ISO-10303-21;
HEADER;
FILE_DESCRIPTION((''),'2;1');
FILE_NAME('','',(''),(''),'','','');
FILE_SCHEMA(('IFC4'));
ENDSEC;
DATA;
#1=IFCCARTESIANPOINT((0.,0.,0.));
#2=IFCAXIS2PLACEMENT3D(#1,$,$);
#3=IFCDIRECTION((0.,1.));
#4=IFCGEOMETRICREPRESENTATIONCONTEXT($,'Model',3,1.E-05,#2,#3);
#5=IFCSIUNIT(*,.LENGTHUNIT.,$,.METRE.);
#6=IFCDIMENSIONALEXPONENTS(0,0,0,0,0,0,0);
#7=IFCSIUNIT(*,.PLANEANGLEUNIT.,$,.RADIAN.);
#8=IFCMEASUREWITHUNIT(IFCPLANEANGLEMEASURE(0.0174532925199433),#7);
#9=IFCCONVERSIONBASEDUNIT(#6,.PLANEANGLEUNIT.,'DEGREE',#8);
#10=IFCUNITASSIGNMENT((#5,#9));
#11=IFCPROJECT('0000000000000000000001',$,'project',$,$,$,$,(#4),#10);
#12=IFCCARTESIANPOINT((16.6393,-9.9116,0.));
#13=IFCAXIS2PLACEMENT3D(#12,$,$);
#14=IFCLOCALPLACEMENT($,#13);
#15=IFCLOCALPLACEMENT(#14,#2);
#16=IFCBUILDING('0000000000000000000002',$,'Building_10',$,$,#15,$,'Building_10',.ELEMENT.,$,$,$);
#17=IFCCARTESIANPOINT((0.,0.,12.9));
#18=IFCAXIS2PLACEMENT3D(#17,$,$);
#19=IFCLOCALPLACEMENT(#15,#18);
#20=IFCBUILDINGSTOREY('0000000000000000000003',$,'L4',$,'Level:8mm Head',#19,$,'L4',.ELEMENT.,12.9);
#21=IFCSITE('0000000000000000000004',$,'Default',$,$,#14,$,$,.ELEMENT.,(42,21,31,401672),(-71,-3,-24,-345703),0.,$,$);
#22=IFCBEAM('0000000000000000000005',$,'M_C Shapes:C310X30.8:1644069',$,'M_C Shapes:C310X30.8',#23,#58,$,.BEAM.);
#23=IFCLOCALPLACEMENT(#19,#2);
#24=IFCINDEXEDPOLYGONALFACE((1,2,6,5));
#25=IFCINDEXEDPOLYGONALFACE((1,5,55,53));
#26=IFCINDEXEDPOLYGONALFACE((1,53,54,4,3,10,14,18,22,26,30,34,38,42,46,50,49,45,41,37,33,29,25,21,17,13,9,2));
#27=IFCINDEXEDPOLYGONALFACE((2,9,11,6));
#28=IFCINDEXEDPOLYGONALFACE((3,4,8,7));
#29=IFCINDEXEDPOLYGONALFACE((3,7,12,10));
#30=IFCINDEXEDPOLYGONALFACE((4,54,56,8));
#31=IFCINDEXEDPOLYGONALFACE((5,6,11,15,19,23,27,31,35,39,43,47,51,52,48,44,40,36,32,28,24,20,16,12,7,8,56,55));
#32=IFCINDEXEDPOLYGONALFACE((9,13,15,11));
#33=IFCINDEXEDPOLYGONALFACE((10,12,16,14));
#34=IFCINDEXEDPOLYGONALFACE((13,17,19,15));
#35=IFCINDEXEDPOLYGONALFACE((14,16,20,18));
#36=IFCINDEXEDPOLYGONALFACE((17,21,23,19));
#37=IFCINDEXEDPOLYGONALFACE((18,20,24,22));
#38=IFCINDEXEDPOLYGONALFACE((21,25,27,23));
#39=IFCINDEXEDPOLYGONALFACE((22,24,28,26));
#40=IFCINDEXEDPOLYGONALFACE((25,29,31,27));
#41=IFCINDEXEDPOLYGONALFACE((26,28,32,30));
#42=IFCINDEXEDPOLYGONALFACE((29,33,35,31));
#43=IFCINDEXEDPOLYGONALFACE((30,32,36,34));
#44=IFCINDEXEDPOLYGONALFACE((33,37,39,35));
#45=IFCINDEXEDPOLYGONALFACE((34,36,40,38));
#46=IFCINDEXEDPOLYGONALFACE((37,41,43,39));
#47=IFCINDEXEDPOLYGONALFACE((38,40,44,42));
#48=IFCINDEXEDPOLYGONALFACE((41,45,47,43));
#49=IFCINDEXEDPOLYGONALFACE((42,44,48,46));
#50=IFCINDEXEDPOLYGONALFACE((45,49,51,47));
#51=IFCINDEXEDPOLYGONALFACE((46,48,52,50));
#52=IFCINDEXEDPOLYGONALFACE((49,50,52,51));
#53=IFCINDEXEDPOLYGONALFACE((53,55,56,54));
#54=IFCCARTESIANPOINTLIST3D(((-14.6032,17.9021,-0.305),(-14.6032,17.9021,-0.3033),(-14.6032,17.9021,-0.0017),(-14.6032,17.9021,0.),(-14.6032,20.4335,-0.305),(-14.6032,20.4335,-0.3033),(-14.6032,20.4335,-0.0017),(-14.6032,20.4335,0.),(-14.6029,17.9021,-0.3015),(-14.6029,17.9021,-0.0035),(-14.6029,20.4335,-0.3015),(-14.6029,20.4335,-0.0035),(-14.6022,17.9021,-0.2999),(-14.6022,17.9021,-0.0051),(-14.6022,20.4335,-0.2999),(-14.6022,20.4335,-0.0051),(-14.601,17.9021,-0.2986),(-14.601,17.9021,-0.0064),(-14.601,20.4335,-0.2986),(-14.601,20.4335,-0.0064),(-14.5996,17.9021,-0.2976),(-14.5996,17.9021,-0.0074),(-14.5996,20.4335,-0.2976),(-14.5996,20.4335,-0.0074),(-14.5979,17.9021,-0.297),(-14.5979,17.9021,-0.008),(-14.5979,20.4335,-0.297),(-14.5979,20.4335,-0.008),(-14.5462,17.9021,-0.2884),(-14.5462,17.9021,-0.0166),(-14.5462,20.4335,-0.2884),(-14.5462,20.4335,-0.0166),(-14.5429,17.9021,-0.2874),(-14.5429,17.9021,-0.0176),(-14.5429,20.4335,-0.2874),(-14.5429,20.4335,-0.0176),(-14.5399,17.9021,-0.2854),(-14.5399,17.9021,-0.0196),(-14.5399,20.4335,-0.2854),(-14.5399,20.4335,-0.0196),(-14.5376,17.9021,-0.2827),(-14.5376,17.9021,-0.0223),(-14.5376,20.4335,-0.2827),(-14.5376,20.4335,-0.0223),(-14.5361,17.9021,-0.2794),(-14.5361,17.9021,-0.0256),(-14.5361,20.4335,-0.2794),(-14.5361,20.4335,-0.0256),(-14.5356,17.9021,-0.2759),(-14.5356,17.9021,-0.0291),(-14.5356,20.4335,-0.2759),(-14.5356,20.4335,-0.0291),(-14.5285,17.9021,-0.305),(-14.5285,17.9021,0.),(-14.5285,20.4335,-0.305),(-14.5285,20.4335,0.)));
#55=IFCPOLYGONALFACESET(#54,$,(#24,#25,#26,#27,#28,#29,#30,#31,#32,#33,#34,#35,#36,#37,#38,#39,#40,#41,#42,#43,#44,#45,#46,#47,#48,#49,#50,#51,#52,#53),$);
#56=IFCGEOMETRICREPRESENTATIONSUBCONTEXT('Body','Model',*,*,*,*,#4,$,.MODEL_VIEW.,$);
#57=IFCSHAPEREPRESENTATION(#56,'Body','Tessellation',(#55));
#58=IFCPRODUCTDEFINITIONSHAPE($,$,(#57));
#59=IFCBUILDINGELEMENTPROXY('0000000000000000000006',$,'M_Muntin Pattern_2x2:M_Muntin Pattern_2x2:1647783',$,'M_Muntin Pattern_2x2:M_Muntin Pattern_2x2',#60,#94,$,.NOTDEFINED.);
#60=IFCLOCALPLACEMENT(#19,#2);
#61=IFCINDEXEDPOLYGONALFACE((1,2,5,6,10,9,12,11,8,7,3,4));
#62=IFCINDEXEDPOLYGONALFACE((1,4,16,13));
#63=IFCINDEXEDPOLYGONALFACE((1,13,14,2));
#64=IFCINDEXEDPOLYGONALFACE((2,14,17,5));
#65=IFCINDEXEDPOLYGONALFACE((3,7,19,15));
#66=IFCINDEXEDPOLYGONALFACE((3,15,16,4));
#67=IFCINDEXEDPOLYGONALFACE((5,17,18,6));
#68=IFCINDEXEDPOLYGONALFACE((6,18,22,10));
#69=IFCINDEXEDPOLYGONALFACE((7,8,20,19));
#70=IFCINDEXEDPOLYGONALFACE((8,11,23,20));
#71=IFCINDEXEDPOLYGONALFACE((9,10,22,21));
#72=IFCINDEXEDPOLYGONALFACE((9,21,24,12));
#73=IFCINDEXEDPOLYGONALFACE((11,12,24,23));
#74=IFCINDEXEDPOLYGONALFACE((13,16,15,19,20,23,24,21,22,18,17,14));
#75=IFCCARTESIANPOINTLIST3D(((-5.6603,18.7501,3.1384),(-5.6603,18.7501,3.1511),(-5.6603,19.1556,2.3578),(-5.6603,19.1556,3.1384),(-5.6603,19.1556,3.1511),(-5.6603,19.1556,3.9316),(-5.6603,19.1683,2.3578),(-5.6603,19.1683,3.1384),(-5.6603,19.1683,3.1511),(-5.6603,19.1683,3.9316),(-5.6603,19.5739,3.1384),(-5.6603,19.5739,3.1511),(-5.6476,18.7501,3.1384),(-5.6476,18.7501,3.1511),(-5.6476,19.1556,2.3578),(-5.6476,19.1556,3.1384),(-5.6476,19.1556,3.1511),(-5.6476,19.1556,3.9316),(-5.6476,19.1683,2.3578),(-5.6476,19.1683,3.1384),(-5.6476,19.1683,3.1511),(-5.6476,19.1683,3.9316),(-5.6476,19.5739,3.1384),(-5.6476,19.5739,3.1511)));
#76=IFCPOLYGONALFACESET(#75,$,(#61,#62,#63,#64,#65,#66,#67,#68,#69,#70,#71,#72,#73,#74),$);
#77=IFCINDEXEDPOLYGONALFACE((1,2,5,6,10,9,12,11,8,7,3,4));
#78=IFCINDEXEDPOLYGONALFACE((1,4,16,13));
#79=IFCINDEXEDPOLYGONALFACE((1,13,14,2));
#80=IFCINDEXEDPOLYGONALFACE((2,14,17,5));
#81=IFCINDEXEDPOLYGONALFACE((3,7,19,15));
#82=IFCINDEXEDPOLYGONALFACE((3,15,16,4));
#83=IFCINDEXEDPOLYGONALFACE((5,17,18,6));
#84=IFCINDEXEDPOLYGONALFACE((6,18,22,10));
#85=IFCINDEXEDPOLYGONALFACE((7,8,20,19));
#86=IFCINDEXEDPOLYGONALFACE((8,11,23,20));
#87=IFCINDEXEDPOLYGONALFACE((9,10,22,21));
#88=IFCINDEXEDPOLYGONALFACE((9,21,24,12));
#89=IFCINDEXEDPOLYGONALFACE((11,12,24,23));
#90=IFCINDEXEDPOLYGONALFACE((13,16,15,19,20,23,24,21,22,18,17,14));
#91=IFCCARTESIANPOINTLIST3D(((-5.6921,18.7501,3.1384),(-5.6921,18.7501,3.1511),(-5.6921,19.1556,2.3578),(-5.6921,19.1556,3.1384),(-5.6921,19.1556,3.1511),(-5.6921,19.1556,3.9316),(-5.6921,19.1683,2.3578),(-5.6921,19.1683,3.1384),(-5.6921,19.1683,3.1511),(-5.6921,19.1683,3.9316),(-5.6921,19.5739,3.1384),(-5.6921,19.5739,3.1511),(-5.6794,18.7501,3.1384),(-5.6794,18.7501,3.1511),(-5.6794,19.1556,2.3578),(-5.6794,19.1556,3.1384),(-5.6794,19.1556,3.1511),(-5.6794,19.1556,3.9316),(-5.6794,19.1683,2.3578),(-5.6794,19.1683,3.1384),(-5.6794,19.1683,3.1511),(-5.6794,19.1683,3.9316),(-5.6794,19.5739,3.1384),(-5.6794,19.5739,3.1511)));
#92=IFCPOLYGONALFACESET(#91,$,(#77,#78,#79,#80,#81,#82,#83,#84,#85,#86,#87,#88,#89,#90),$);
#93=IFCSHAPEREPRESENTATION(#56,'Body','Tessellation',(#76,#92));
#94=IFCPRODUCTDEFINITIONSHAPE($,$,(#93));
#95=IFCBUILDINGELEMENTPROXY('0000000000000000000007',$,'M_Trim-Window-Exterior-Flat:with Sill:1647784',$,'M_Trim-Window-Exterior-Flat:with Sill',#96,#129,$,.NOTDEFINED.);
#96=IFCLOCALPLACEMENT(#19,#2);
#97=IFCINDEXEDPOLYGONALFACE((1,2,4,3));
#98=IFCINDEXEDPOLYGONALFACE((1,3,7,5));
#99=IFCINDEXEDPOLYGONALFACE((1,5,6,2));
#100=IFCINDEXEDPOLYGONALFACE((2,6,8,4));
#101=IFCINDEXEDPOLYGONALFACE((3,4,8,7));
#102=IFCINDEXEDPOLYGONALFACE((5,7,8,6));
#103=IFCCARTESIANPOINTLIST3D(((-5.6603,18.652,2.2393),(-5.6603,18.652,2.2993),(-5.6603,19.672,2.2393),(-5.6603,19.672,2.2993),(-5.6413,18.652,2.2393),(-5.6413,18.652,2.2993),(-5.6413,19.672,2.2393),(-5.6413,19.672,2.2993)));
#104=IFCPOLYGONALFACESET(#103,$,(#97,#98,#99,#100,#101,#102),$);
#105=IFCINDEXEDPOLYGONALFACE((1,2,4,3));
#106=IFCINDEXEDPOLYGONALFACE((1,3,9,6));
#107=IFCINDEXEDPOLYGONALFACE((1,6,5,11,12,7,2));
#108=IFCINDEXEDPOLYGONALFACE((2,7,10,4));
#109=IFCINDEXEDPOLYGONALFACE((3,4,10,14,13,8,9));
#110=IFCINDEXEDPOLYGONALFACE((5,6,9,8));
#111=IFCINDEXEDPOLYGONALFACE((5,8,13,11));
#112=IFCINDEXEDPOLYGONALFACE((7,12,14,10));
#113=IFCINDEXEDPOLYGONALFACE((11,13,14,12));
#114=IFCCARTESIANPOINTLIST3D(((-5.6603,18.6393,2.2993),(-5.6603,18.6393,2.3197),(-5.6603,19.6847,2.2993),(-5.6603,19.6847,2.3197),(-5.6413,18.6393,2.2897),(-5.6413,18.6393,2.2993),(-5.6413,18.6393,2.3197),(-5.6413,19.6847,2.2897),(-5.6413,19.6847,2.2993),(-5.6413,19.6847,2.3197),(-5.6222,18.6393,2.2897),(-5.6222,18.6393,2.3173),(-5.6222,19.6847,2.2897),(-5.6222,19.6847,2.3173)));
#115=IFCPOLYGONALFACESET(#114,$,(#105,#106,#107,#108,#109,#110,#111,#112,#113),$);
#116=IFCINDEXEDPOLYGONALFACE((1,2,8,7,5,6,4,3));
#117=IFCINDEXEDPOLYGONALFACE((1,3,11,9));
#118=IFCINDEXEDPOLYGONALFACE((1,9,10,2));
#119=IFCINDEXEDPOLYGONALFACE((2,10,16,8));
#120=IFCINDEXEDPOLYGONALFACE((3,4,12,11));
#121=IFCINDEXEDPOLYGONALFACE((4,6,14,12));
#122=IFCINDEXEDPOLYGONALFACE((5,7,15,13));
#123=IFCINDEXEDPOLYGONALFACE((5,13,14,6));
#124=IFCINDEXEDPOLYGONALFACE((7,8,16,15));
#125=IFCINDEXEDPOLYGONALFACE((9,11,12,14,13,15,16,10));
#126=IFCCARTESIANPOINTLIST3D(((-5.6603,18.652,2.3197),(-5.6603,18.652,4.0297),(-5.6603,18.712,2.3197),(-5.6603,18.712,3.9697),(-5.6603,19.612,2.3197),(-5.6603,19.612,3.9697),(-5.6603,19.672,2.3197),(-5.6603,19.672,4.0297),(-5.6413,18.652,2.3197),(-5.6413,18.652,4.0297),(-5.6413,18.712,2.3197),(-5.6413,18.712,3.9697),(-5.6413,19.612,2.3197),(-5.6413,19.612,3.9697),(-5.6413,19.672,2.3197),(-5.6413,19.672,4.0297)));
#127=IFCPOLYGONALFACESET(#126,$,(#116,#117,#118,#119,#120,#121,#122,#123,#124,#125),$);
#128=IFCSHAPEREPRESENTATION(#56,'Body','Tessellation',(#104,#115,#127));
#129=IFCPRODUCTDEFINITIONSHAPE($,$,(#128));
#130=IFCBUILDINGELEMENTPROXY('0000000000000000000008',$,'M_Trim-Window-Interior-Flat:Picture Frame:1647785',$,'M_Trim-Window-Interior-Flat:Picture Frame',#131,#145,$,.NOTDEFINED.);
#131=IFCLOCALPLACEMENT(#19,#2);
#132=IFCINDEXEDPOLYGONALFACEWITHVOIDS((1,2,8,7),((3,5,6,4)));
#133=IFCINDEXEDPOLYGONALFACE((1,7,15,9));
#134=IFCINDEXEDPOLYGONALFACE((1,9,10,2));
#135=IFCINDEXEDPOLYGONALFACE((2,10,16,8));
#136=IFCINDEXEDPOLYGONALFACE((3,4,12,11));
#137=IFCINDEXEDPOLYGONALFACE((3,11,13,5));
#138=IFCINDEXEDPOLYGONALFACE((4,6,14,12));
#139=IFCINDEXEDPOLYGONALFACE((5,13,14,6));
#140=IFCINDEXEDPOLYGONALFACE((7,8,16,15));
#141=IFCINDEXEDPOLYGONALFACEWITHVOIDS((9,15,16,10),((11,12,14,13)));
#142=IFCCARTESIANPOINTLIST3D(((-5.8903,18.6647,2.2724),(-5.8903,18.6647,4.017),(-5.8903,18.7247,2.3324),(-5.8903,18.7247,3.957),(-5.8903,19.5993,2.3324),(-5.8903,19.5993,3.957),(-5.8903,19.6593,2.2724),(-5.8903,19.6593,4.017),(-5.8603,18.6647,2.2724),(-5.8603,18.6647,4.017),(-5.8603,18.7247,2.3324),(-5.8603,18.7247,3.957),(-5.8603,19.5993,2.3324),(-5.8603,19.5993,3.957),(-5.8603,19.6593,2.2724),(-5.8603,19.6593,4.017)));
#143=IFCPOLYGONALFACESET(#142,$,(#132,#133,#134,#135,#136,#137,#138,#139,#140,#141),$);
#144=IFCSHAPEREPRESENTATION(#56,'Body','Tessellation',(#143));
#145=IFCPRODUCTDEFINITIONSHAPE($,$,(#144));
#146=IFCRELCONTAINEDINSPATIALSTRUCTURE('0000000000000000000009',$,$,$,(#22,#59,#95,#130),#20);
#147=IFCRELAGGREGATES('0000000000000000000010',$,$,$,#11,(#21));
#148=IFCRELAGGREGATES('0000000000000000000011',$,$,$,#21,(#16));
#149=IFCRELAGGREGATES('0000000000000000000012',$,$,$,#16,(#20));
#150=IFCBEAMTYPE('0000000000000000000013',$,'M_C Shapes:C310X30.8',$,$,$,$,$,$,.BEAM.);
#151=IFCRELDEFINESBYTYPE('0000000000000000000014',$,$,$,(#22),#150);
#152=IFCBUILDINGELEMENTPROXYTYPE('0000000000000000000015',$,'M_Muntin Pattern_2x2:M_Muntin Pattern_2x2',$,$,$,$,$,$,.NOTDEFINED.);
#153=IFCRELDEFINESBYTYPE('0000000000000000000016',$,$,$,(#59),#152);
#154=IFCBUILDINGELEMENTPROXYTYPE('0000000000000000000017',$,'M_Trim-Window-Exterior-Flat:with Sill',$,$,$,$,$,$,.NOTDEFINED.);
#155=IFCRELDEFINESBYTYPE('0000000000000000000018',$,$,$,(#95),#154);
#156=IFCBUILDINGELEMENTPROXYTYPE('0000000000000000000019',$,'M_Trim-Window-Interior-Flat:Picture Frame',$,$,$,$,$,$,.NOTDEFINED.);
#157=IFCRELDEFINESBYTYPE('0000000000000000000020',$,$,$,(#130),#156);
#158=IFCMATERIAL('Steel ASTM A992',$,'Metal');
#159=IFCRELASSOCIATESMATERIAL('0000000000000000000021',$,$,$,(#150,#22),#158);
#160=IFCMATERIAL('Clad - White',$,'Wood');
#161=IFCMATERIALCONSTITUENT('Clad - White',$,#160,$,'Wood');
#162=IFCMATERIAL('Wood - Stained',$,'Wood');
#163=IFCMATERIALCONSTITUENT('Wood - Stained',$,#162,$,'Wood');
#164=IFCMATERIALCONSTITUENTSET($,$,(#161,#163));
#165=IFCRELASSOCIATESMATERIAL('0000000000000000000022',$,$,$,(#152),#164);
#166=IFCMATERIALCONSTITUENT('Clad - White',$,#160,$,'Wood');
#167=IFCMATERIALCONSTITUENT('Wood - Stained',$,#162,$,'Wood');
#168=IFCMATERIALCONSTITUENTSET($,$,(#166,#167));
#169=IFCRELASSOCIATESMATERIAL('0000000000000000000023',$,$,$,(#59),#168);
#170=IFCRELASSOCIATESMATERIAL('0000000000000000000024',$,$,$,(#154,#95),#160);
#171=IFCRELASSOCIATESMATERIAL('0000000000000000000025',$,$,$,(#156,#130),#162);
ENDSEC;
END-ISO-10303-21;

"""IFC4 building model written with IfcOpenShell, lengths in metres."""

from ifc_helpers import new_model, entity, si_unit, converted_unit, direction, frame, origin, place, context, subcontext, project, spatial, line, arc, indexed_curve, outline, extrude, source, transform, mapped, material, constituent, constituent_set, type_object, type_shapes, element, save


model = new_model("IFC4")

# Units and contexts
model_context = context("Model", 3, precision=1e-05, world=origin(), true_north=direction((0.0, 1.0)))
body_context = subcontext(model_context, "Body", "Model", "MODEL_VIEW")
ifc_project = project(units=[si_unit("LENGTHUNIT", "METRE"), converted_unit("PLANEANGLEUNIT", "DEGREE", entity("IfcPlaneAngleMeasure", 0.0174532925199433), si_unit("PLANEANGLEUNIT", "RADIAN"), dimensions=[0, 0, 0, 0, 0, 0, 0])], contexts=[model_context])

# Site, building, storey
site_placement = place(None, frame((16.6393, -9.9116, 0.0)))
site = spatial("IfcSite", under=ifc_project, at=site_placement, Name="Default", CompositionType="ELEMENT", RefLatitude=(42, 21, 31, 401672), RefLongitude=(-71, -3, -24, -345703), RefElevation=0.0)
building_placement = place(site_placement, origin())
building = spatial("IfcBuilding", under=site, at=building_placement, Name="Building_10", LongName="Building_10", CompositionType="ELEMENT")
storey_placement = place(building_placement, frame((0.0, 0.0, 12.9)))
storey = spatial("IfcBuildingStorey", under=building, at=storey_placement, Name="L4", ObjectType="Level:8mm Head", LongName="L4", CompositionType="ELEMENT", Elevation=12.9)

# Shared definitions
ifc_material_1 = material(Name="Steel ASTM A992", Category="Metal")

# Beam
beam_type_1 = type_object("IfcBeamType", Name="M_C Shapes:C310X30.8", PredefinedType="BEAM", material=ifc_material_1)
shared_shape_1 = source(origin(), body_context, "Body", "SweptSolid", [
    extrude(outline(indexed_curve([(-0.0406, -0.1525), (0.0341, -0.1525), (0.0341, -0.1508), (0.0326, -0.1467), (0.0288, -0.1445), (-0.0228, -0.1359), (-0.0305, -0.1316), (-0.0335, -0.1234), (-0.0335, 0.1234), (-0.0305, 0.1316), (-0.0228, 0.1359), (0.0288, 0.1445), (0.0326, 0.1467), (0.0341, 0.1508), (0.0341, 0.1525), (-0.0406, 0.1525)], segments=[line(1, 2, 3), arc(3, 4, 5), line(5, 6), arc(6, 7, 8), line(8, 9), arc(9, 10, 11), line(11, 12), arc(12, 13, 14), line(14, 15, 16, 1)], self_intersect=False)), frame((-1.2657, -0.0229, 0.0), z_axis=(1.0, 0.0, 0.0), x_axis=(0.0, -1.0, 0.0)), (0.0, 0.0, 1.0), 2.5314),
])
type_shapes(beam_type_1, [shared_shape_1])
for number, where, z_axis, x_axis, name in (
    (1, (-14.5462, 19.1678, -0.1525), (0.0, 0.0, 1.0), (0.0, -1.0, 0.0), "M_C Shapes:C310X30.8:1644069"),
):
    element("IfcBeam", number, at=place(storey_placement, frame(where, z_axis=z_axis, x_axis=x_axis)), inside=storey, type_object=beam_type_1, material=ifc_material_1, Name=name, ObjectType="M_C Shapes:C310X30.8", PredefinedType="BEAM", context=body_context, shape_type="MappedRepresentation", body=[
        mapped(shared_shape_1, transform((0.0, 0.0, 0.0), scale=1.0)),
    ])

# Building element proxies
ifc_material_2 = material(Name="Clad - White", Category="Wood")
ifc_constituent_1 = constituent(ifc_material_2, Name="Clad - White", Category="Wood")
ifc_material_3 = material(Name="Wood - Stained", Category="Wood")
ifc_constituent_2 = constituent(ifc_material_3, Name="Wood - Stained", Category="Wood")
ifc_constituent_set_1 = constituent_set(constituents=[ifc_constituent_1, ifc_constituent_2])
ifc_constituent_3 = constituent(ifc_material_2, Name="Clad - White", Category="Wood")
ifc_constituent_4 = constituent(ifc_material_3, Name="Wood - Stained", Category="Wood")
ifc_constituent_set_2 = constituent_set(constituents=[ifc_constituent_3, ifc_constituent_4])
building_element_proxy_type_1 = type_object("IfcBuildingElementProxyType", Name="M_Muntin Pattern_2x2:M_Muntin Pattern_2x2", PredefinedType="NOTDEFINED", material=ifc_constituent_set_2)
shared_shape_2 = source(origin(), body_context, "Body", "SweptSolid", [
    extrude(outline(indexed_curve([(0.0064, -0.0064), (0.7869, -0.0064), (0.7869, 0.0063), (0.0064, 0.0063), (0.0064, 0.4119), (-0.0063, 0.4119), (-0.0063, 0.0063), (-0.7869, 0.0063), (-0.7869, -0.0064), (-0.0063, -0.0064), (-0.0063, -0.4119), (0.0064, -0.4119), (0.0064, -0.0064)], self_intersect=False)), frame((0.0, -0.0222, 0.7869), z_axis=(0.0, 1.0, 0.0), x_axis=(0.0, 0.0, 1.0)), (0.0, 0.0, 1.0), 0.0127),
    extrude(outline(indexed_curve([(0.0064, -0.0064), (0.7869, -0.0064), (0.7869, 0.0063), (0.0064, 0.0063), (0.0064, 0.4119), (-0.0063, 0.4119), (-0.0063, 0.0063), (-0.7869, 0.0063), (-0.7869, -0.0064), (-0.0063, -0.0064), (-0.0063, -0.4119), (0.0064, -0.4119), (0.0064, -0.0064)], self_intersect=False)), frame((0.0, 0.0095, 0.7869), z_axis=(0.0, 1.0, 0.0), x_axis=(0.0, 0.0, 1.0)), (0.0, 0.0, 1.0), 0.0127),
])
type_shapes(building_element_proxy_type_1, [shared_shape_2])
proxy_1_placement = place(storey_placement, frame((-5.6698, 19.162, 2.3578), z_axis=(0.0, 0.0, 1.0), x_axis=(0.0, 1.0, 0.0)))
element("IfcBuildingElementProxy", 2, at=proxy_1_placement, inside=storey, type_object=building_element_proxy_type_1, material=ifc_constituent_set_1, Name="M_Muntin Pattern_2x2:M_Muntin Pattern_2x2:1647783", ObjectType="M_Muntin Pattern_2x2:M_Muntin Pattern_2x2", PredefinedType="NOTDEFINED", context=body_context, shape_type="MappedRepresentation", body=[
    mapped(shared_shape_2, transform((0.0, 0.0, 0.0), scale=1.0)),
])
building_element_proxy_type_2 = type_object("IfcBuildingElementProxyType", Name="M_Trim-Window-Exterior-Flat:with Sill", PredefinedType="NOTDEFINED", material=ifc_material_2)
shared_shape_3 = source(origin(), body_context, "Body", "SweptSolid", [
    extrude(outline(indexed_curve([(-0.51, -0.03), (0.51, -0.03), (0.51, 0.03), (-0.51, 0.03), (-0.51, -0.03)], self_intersect=False)), frame((0.0, -1.7004, 0.0), z_axis=(0.0, 0.0, 1.0), x_axis=(-1.0, 0.0, 0.0)), (0.0, 0.0, 1.0), 0.0191),
    extrude(outline(indexed_curve([(-0.019, -0.0152), (0.0, -0.0152), (0.0, -0.0057), (0.019, -0.0057), (0.019, 0.0148), (0.0, 0.0148), (-0.019, 0.0123), (-0.019, -0.0152)], self_intersect=False)), frame((-0.5227, -1.6648, 0.019), z_axis=(1.0, 0.0, 0.0), x_axis=(0.0, 0.0, -1.0)), (0.0, 0.0, 1.0), 1.0454),
    extrude(outline(indexed_curve([(-0.87, -0.51), (0.84, -0.51), (0.84, -0.45), (-0.81, -0.45), (-0.81, 0.45), (0.84, 0.45), (0.84, 0.51), (-0.87, 0.51), (-0.87, -0.51)], self_intersect=False)), frame((0.0, -0.81, 0.0), z_axis=(0.0, 0.0, 1.0), x_axis=(0.0, -1.0, 0.0)), (0.0, 0.0, 1.0), 0.0191),
])
type_shapes(building_element_proxy_type_2, [shared_shape_3])
proxy_2_placement = place(storey_placement, frame((-5.6603, 19.162, 3.9697), z_axis=(1.0, 0.0, 0.0), x_axis=(0.0, 1.0, 0.0)))
element("IfcBuildingElementProxy", 3, at=proxy_2_placement, inside=storey, type_object=building_element_proxy_type_2, material=ifc_material_2, Name="M_Trim-Window-Exterior-Flat:with Sill:1647784", ObjectType="M_Trim-Window-Exterior-Flat:with Sill", PredefinedType="NOTDEFINED", context=body_context, shape_type="MappedRepresentation", body=[
    mapped(shared_shape_3, transform((0.0, 0.0, 0.0), scale=1.0)),
])
building_element_proxy_type_3 = type_object("IfcBuildingElementProxyType", Name="M_Trim-Window-Interior-Flat:Picture Frame", PredefinedType="NOTDEFINED", material=ifc_material_3)
shared_shape_4 = source(origin(), body_context, "Body", "SweptSolid", [
    extrude(outline(indexed_curve([(-0.4973, -0.8723), (0.4973, -0.8723), (0.4973, 0.8723), (-0.4973, 0.8723), (-0.4973, -0.8723)], self_intersect=False), holes=[indexed_curve([(-0.4373, -0.8123), (-0.4373, 0.8123), (0.4373, 0.8123), (0.4373, -0.8123), (-0.4373, -0.8123)], self_intersect=False)]), frame((0.0, -0.825, 0.0), z_axis=(0.0, 0.0, 1.0), x_axis=(-1.0, 0.0, 0.0)), (0.0, 0.0, 1.0), 0.03),
])
type_shapes(building_element_proxy_type_3, [shared_shape_4])
proxy_3_placement = place(storey_placement, frame((-5.8603, 19.162, 3.9697), z_axis=(-1.0, 0.0, 0.0), x_axis=(0.0, -1.0, 0.0)))
element("IfcBuildingElementProxy", 4, at=proxy_3_placement, inside=storey, type_object=building_element_proxy_type_3, material=ifc_material_3, Name="M_Trim-Window-Interior-Flat:Picture Frame:1647785", ObjectType="M_Trim-Window-Interior-Flat:Picture Frame", PredefinedType="NOTDEFINED", context=body_context, shape_type="MappedRepresentation", body=[
    mapped(shared_shape_4, transform((0.0, 0.0, 0.0), scale=1.0)),
])

save(model, "model.ifc")
